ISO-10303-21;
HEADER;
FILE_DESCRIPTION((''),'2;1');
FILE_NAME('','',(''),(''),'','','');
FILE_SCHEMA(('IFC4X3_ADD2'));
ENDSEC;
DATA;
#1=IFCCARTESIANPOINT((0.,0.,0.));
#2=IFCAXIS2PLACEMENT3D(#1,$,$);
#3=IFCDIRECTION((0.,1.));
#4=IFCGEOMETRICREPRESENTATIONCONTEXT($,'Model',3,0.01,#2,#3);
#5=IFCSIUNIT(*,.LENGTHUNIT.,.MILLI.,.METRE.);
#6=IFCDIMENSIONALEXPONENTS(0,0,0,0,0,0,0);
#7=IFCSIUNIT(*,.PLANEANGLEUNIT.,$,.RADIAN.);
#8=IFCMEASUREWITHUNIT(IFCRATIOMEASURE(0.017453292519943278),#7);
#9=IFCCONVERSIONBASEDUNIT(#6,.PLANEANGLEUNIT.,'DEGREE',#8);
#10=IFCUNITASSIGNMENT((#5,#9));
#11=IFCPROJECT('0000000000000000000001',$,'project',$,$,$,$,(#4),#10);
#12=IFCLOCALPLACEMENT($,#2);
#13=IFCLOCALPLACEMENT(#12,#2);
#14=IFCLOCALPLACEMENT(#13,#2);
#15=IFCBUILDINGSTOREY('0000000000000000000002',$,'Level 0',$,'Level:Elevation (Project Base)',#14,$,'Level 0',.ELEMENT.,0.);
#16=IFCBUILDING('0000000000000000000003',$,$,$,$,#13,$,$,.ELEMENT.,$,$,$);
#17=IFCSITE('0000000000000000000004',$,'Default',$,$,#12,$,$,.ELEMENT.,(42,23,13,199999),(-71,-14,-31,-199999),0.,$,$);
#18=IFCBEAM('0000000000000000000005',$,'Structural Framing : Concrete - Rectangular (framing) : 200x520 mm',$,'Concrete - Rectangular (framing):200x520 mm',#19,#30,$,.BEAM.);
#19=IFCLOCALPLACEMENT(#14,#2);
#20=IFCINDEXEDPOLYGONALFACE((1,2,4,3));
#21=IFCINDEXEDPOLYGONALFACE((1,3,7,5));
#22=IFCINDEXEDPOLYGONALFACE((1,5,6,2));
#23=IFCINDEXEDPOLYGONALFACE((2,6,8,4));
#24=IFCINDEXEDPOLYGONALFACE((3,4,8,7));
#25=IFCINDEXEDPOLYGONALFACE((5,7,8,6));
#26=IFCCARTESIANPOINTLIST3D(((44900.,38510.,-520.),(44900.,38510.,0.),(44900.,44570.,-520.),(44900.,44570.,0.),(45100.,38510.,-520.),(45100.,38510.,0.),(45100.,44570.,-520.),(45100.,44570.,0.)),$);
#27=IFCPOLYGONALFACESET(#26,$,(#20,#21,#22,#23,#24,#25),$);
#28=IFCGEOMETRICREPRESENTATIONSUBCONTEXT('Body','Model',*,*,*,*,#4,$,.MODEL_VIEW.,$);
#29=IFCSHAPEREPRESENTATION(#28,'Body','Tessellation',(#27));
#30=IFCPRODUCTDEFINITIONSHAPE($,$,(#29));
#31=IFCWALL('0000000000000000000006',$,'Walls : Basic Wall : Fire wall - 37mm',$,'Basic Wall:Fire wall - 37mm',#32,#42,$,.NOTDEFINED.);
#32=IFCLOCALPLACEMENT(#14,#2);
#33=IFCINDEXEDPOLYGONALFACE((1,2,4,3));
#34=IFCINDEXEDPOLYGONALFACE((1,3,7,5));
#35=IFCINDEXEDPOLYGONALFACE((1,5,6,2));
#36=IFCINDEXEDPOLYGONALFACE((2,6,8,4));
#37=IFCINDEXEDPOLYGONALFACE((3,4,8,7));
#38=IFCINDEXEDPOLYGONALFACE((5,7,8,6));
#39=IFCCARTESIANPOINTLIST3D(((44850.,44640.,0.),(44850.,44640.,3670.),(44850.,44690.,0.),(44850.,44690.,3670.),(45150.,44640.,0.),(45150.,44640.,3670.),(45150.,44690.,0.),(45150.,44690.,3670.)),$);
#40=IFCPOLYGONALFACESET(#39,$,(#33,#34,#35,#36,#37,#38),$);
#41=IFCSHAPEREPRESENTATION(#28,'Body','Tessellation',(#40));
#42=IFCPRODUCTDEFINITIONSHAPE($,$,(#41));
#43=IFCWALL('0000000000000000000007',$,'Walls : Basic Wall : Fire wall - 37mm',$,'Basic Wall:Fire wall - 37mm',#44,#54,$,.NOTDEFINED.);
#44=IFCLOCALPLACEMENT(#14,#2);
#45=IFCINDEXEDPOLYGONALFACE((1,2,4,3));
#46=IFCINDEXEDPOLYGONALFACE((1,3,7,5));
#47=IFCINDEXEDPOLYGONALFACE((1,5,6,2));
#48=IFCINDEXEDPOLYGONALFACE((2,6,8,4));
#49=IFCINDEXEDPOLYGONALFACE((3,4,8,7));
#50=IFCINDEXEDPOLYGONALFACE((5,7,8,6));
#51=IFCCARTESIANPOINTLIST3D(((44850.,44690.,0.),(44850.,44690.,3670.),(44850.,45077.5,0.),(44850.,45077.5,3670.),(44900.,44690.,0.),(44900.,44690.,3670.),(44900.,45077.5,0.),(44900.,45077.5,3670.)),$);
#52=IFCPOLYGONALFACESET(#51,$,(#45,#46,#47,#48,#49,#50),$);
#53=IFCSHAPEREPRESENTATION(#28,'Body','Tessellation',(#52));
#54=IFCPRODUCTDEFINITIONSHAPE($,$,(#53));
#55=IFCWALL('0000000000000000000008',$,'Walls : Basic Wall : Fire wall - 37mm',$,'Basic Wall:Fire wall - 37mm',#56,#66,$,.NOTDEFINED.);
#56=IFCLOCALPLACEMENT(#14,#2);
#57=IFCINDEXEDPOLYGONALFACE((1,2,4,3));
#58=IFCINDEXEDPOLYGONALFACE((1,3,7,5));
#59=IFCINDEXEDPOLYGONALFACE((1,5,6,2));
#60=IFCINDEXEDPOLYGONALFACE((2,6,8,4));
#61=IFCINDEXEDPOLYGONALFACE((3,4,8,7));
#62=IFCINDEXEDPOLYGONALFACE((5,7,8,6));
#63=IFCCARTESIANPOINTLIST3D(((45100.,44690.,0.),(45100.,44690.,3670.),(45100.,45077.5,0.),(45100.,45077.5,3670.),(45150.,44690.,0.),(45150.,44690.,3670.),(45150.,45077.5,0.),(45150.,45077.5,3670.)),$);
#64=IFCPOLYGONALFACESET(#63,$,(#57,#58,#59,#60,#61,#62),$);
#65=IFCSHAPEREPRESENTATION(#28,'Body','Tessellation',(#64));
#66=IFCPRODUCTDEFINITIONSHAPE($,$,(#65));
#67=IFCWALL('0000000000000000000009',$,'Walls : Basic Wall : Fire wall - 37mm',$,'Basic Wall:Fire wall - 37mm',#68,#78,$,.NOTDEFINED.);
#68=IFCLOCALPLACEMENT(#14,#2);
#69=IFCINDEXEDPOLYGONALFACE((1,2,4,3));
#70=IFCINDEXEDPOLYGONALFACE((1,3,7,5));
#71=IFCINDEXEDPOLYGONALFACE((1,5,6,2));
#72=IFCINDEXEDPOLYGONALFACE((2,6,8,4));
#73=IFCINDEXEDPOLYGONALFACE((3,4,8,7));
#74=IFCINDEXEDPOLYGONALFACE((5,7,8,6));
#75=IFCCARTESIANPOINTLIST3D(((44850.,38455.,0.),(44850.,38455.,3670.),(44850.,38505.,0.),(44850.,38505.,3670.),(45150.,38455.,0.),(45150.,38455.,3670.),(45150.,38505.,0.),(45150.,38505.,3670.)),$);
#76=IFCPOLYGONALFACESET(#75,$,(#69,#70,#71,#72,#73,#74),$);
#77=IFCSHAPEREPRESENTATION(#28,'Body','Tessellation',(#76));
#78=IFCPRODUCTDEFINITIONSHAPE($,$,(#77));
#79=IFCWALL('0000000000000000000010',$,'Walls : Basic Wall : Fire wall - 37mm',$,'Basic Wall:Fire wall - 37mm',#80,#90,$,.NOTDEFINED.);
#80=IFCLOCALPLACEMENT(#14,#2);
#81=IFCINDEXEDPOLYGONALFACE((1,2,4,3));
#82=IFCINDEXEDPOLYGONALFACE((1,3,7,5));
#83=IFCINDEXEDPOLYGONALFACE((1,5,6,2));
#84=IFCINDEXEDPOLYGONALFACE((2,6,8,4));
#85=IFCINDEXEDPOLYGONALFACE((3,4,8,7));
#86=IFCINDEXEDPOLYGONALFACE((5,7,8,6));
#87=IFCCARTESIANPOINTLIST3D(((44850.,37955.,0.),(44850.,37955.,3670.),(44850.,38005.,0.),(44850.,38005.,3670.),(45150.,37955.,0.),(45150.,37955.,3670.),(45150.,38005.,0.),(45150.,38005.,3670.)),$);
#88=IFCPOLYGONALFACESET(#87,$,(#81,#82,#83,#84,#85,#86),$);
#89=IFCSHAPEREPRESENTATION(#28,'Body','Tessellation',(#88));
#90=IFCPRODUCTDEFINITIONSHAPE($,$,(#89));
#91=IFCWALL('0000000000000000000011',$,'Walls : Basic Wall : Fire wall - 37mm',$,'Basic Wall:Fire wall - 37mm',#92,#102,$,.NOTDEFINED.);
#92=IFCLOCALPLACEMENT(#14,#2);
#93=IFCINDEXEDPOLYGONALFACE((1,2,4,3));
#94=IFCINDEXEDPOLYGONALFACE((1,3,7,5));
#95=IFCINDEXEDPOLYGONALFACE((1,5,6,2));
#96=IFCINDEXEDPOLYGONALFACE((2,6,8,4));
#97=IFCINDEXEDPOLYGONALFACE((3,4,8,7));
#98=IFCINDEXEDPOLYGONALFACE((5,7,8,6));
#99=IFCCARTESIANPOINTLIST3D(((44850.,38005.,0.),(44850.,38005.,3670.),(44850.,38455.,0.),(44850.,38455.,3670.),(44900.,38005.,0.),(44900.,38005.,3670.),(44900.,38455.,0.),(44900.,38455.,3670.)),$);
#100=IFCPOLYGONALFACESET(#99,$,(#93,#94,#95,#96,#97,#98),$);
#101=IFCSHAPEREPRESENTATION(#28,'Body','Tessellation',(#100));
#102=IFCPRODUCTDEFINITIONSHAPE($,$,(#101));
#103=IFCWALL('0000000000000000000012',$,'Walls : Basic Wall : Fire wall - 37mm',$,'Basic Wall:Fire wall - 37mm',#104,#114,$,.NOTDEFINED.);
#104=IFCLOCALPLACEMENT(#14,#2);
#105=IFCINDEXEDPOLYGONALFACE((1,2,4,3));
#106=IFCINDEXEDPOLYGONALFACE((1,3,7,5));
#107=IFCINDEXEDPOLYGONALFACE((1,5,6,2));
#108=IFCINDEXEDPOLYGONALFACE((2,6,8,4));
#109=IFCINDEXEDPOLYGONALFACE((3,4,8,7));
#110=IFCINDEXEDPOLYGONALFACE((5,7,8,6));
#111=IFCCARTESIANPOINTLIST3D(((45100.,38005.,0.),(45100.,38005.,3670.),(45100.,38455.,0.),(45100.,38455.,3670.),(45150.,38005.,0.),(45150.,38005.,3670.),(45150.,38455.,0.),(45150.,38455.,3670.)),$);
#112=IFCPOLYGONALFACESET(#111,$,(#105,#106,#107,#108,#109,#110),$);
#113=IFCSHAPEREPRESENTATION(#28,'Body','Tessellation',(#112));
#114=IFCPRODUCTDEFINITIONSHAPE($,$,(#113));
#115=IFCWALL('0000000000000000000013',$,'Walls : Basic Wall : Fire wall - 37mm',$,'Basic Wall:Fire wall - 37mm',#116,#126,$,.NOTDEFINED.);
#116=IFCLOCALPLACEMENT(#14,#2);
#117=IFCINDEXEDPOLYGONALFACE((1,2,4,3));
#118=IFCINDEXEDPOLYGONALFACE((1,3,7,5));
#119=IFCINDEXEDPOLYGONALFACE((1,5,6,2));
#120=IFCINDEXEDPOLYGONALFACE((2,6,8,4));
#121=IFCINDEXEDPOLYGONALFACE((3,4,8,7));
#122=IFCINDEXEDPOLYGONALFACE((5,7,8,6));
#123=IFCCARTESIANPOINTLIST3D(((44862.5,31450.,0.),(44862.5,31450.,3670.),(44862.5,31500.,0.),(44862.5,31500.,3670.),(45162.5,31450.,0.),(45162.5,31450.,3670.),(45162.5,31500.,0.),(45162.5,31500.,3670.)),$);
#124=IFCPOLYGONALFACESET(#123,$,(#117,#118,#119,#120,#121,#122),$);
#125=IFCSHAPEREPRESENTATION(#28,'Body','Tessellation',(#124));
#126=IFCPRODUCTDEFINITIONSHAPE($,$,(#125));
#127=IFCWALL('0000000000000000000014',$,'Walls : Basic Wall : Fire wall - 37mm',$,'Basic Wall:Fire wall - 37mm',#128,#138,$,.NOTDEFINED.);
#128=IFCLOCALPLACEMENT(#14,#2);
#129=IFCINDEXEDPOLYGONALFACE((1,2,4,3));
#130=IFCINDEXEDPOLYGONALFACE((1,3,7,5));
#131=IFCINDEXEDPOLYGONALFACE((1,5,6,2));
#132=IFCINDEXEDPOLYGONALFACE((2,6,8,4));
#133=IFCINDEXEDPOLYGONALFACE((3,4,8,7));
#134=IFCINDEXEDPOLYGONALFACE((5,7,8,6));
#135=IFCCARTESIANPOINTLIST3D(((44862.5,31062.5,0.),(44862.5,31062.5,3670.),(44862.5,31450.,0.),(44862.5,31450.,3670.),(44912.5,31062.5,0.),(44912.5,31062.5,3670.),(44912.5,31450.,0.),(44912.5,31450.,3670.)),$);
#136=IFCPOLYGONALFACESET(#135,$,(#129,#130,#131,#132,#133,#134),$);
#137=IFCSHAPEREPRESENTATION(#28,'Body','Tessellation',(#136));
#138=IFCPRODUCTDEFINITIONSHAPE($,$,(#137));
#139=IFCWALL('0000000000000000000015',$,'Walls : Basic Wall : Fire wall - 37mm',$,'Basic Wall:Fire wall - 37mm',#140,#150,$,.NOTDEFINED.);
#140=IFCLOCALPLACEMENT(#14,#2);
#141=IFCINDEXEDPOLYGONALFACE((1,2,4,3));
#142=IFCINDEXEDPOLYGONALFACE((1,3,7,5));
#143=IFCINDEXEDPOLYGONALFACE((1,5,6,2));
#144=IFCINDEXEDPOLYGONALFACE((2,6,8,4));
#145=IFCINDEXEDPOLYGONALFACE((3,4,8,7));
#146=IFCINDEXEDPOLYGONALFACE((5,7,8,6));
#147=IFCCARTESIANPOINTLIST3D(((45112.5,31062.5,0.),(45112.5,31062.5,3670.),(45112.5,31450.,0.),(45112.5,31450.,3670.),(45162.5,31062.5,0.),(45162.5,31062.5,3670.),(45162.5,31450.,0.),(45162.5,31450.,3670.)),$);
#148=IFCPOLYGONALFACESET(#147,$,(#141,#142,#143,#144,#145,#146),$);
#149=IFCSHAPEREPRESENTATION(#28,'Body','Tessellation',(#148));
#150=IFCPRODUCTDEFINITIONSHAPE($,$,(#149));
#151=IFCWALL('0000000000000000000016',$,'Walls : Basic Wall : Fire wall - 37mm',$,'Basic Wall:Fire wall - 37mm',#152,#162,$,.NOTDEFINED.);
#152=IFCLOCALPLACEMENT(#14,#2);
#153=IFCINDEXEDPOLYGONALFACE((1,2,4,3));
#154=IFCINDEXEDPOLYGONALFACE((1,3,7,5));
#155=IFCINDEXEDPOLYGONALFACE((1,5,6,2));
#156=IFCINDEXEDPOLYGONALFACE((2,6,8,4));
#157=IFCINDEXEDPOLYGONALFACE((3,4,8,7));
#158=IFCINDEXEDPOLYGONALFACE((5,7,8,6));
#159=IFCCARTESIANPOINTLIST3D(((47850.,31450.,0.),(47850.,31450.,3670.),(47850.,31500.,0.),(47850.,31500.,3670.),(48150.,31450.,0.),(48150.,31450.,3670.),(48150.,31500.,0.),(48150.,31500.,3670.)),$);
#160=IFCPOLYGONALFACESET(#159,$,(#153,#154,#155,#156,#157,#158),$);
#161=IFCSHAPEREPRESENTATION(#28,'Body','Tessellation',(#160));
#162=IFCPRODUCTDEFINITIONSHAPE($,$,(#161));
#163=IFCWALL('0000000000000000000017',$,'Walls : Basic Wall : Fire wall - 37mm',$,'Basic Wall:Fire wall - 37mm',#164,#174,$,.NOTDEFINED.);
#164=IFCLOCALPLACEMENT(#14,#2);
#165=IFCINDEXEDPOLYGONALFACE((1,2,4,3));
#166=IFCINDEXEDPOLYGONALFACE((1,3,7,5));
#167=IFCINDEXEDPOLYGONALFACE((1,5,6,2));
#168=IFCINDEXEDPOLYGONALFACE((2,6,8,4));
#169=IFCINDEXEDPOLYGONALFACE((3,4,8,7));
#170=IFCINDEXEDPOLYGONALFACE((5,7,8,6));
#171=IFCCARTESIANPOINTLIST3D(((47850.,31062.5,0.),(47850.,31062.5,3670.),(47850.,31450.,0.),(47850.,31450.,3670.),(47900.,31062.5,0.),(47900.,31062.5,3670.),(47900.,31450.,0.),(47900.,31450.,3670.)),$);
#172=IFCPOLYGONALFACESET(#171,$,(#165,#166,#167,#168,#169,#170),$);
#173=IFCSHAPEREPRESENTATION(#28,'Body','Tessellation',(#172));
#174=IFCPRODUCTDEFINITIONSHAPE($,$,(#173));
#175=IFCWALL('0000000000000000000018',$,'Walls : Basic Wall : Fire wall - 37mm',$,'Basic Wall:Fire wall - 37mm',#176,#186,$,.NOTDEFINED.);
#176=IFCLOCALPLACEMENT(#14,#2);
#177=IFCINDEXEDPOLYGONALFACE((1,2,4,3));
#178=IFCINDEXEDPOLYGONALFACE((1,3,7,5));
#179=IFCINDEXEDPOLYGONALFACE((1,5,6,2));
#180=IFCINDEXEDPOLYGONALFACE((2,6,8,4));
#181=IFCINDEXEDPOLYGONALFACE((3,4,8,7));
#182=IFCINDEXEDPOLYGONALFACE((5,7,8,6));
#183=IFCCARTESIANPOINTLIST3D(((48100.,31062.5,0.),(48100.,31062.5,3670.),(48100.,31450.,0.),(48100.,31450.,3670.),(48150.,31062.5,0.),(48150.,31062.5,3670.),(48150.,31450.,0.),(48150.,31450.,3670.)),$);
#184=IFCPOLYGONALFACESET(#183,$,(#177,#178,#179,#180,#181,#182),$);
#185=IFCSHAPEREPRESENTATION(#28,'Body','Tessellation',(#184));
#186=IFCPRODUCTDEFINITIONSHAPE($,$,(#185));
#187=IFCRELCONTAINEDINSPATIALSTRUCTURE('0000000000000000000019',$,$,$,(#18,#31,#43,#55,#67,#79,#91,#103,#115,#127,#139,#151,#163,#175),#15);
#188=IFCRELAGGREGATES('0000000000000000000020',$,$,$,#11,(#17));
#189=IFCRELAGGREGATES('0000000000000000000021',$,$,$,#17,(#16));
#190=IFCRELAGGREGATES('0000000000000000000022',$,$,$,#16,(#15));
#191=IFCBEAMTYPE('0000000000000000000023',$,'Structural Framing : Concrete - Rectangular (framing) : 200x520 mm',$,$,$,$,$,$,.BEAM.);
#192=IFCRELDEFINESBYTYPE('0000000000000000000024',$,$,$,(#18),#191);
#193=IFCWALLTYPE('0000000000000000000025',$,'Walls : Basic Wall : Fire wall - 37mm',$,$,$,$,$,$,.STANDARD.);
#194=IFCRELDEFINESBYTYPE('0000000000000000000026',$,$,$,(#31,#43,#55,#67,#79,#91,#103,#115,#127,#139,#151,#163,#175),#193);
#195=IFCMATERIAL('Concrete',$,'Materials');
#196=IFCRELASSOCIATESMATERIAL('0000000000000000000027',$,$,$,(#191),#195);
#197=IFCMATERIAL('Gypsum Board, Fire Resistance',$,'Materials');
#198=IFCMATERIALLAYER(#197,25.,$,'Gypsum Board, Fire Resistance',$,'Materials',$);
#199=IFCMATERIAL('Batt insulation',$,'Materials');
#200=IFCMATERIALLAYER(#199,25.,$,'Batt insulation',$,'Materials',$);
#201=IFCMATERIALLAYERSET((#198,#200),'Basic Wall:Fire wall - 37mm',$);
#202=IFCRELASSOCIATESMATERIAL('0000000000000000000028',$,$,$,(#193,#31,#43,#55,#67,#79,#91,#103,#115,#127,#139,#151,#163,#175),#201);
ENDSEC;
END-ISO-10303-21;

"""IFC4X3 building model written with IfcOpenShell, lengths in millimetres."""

from ifc_helpers import new_model, entity, si_unit, converted_unit, direction, frame, frame_2d, origin, place, context, subcontext, project, spatial, rectangle, extrude, source, transform, mapped, material, layer, layer_set, material_profile, profile_set, type_object, type_shapes, element, save


model = new_model("IFC4X3")

# Units and contexts
model_context = context("Model", 3, precision=0.01, world=origin(), true_north=direction((0.0, 1.0)))
body_context = subcontext(model_context, "Body", "Model", "MODEL_VIEW")
ifc_project = project(units=[si_unit("LENGTHUNIT", "METRE", prefix="MILLI"), converted_unit("PLANEANGLEUNIT", "DEGREE", entity("IfcRatioMeasure", 0.017453292519943278), si_unit("PLANEANGLEUNIT", "RADIAN"), dimensions=[0, 0, 0, 0, 0, 0, 0])], contexts=[model_context])

# Site, building, storey
site_placement = place(None, origin())
site = spatial("IfcSite", under=ifc_project, at=site_placement, Name="Default", CompositionType="ELEMENT", RefLatitude=(42, 23, 13, 199999), RefLongitude=(-71, -14, -31, -199999), RefElevation=0.0)
building_placement = place(site_placement, origin())
building = spatial("IfcBuilding", under=site, at=building_placement, CompositionType="ELEMENT")
storey_placement = place(building_placement, origin())
storey = spatial("IfcBuildingStorey", under=building, at=storey_placement, Name="Level 0", ObjectType="Level:Elevation (Project Base)", LongName="Level 0", CompositionType="ELEMENT", Elevation=0.0)

# Beam
ifc_material_1 = material(Name="Concrete", Category="Materials")
ifc_material_profile = material_profile(ifc_material_1, rectangle(XDim=520.0, YDim=200.0, at=frame_2d((0.0, 0.0), x_axis=(1.0, 0.0))), Name="200x520 mm")
ifc_profile_set = profile_set([ifc_material_profile], Name="200x520 mm")
beam_type = type_object("IfcBeamType", Name="Structural Framing : Concrete - Rectangular (framing) : 200x520 mm", PredefinedType="BEAM", material=ifc_profile_set)
shared_shape = source(origin(), body_context, "Body", "SweptSolid", [
    extrude(rectangle(XDim=520.0, YDim=200.0, at=frame_2d((0.0, 0.0), x_axis=(1.0, 0.0))), frame((-1230.0, 0.0, 0.0), z_axis=(1.0, 0.0, 0.0), x_axis=(0.0, 0.0, -1.0)), (0.0, 0.0, 1.0), 6060.0),
])
type_shapes(beam_type, [shared_shape])
beam_placement = place(storey_placement, frame((45000.0, 43340.0, -260.0), z_axis=(0.0, 0.0, 1.0), x_axis=(0.0, -1.0, 0.0)))
element("IfcBeam", 1, at=beam_placement, inside=storey, type_object=beam_type, Name="Structural Framing : Concrete - Rectangular (framing) : 200x520 mm", ObjectType="Concrete - Rectangular (framing):200x520 mm", PredefinedType="BEAM", context=body_context, shape_type="MappedRepresentation", body=[
    mapped(shared_shape, transform((0.0, 0.0, 0.0), scale=1.0)),
])

# Walls
ifc_material_2 = material(Name="Gypsum Board, Fire Resistance", Category="Materials")
ifc_layer_1 = layer(ifc_material_2, 25.0, Name="Gypsum Board, Fire Resistance", Category="Materials")
ifc_material_3 = material(Name="Batt insulation", Category="Materials")
ifc_layer_2 = layer(ifc_material_3, 25.0, Name="Batt insulation", Category="Materials")
ifc_layer_set = layer_set([ifc_layer_1, ifc_layer_2], Name="Basic Wall:Fire wall - 37mm")
wall_type = type_object("IfcWallType", Name="Walls : Basic Wall : Fire wall - 37mm", PredefinedType="STANDARD", material=ifc_layer_set)
wall_1_placement = place(storey_placement, frame((44850.0, 44665.0, 0.0)))
element("IfcWall", 2, at=wall_1_placement, inside=storey, type_object=wall_type, material=ifc_layer_set, Name="Walls : Basic Wall : Fire wall - 37mm", ObjectType="Basic Wall:Fire wall - 37mm", PredefinedType="NOTDEFINED", context=body_context, shape_type="SweptSolid", body=[
    extrude(rectangle(XDim=300.0, YDim=50.0, at=frame_2d((150.0, 0.0), x_axis=(-1.0, 0.0))), origin(), (0.0, 0.0, 1.0), 3670.0),
])
for number, where, z_axis, x_axis, name in (
    (3, (44875.0, 45077.5, 0.0), (0.0, 0.0, 1.0), (0.0, -1.0, 0.0), "Walls : Basic Wall : Fire wall - 37mm"),
    (4, (45125.0, 45077.5, 0.0), (0.0, 0.0, 1.0), (0.0, -1.0, 0.0), "Walls : Basic Wall : Fire wall - 37mm"),
):
    element("IfcWall", number, at=place(storey_placement, frame(where, z_axis=z_axis, x_axis=x_axis)), inside=storey, type_object=wall_type, material=ifc_layer_set, Name=name, ObjectType="Basic Wall:Fire wall - 37mm", PredefinedType="NOTDEFINED", context=body_context, shape_type="SweptSolid", body=[
        extrude(rectangle(XDim=387.5, YDim=50.0, at=frame_2d((193.7, 0.0), x_axis=(-1.0, 0.0))), origin(), (0.0, 0.0, 1.0), 3670.0),
    ])
wall_2_placement = place(storey_placement, frame((44850.0, 38480.0, 0.0)))
element("IfcWall", 5, at=wall_2_placement, inside=storey, type_object=wall_type, material=ifc_layer_set, Name="Walls : Basic Wall : Fire wall - 37mm", ObjectType="Basic Wall:Fire wall - 37mm", PredefinedType="NOTDEFINED", context=body_context, shape_type="SweptSolid", body=[
    extrude(rectangle(XDim=300.0, YDim=50.0, at=frame_2d((150.0, 0.0), x_axis=(-1.0, 0.0))), origin(), (0.0, 0.0, 1.0), 3670.0),
])
wall_3_placement = place(storey_placement, frame((44850.0, 37980.0, 0.0)))
element("IfcWall", 6, at=wall_3_placement, inside=storey, type_object=wall_type, material=ifc_layer_set, Name="Walls : Basic Wall : Fire wall - 37mm", ObjectType="Basic Wall:Fire wall - 37mm", PredefinedType="NOTDEFINED", context=body_context, shape_type="SweptSolid", body=[
    extrude(rectangle(XDim=300.0, YDim=50.0, at=frame_2d((150.0, 0.0), x_axis=(-1.0, 0.0))), origin(), (0.0, 0.0, 1.0), 3670.0),
])
for number, where, z_axis, x_axis, name in (
    (7, (44875.0, 38455.0, 0.0), (0.0, 0.0, 1.0), (0.0, -1.0, 0.0), "Walls : Basic Wall : Fire wall - 37mm"),
    (8, (45125.0, 38455.0, 0.0), (0.0, 0.0, 1.0), (0.0, -1.0, 0.0), "Walls : Basic Wall : Fire wall - 37mm"),
):
    element("IfcWall", number, at=place(storey_placement, frame(where, z_axis=z_axis, x_axis=x_axis)), inside=storey, type_object=wall_type, material=ifc_layer_set, Name=name, ObjectType="Basic Wall:Fire wall - 37mm", PredefinedType="NOTDEFINED", context=body_context, shape_type="SweptSolid", body=[
        extrude(rectangle(XDim=450.0, YDim=50.0, at=frame_2d((225.0, 0.0), x_axis=(-1.0, 0.0))), origin(), (0.0, 0.0, 1.0), 3670.0),
    ])
wall_4_placement = place(storey_placement, frame((44862.5, 31475.0, 0.0)))
element("IfcWall", 9, at=wall_4_placement, inside=storey, type_object=wall_type, material=ifc_layer_set, Name="Walls : Basic Wall : Fire wall - 37mm", ObjectType="Basic Wall:Fire wall - 37mm", PredefinedType="NOTDEFINED", context=body_context, shape_type="SweptSolid", body=[
    extrude(rectangle(XDim=300.0, YDim=50.0, at=frame_2d((150.0, 0.0), x_axis=(-1.0, 0.0))), origin(), (0.0, 0.0, 1.0), 3670.0),
])
for number, where, z_axis, x_axis, name in (
    (10, (44887.5, 31450.0, 0.0), (0.0, 0.0, 1.0), (0.0, -1.0, 0.0), "Walls : Basic Wall : Fire wall - 37mm"),
    (11, (45137.5, 31450.0, 0.0), (0.0, 0.0, 1.0), (0.0, -1.0, 0.0), "Walls : Basic Wall : Fire wall - 37mm"),
):
    element("IfcWall", number, at=place(storey_placement, frame(where, z_axis=z_axis, x_axis=x_axis)), inside=storey, type_object=wall_type, material=ifc_layer_set, Name=name, ObjectType="Basic Wall:Fire wall - 37mm", PredefinedType="NOTDEFINED", context=body_context, shape_type="SweptSolid", body=[
        extrude(rectangle(XDim=387.5, YDim=50.0, at=frame_2d((193.8, 0.0), x_axis=(-1.0, 0.0))), origin(), (0.0, 0.0, 1.0), 3670.0),
    ])
wall_5_placement = place(storey_placement, frame((47850.0, 31475.0, 0.0)))
element("IfcWall", 12, at=wall_5_placement, inside=storey, type_object=wall_type, material=ifc_layer_set, Name="Walls : Basic Wall : Fire wall - 37mm", ObjectType="Basic Wall:Fire wall - 37mm", PredefinedType="NOTDEFINED", context=body_context, shape_type="SweptSolid", body=[
    extrude(rectangle(XDim=300.0, YDim=50.0, at=frame_2d((150.0, 0.0), x_axis=(-1.0, 0.0))), origin(), (0.0, 0.0, 1.0), 3670.0),
])
wall_6_placement = place(storey_placement, frame((47875.0, 31450.0, 0.0), z_axis=(0.0, 0.0, 1.0), x_axis=(0.0, -1.0, 0.0)))
element("IfcWall", 13, at=wall_6_placement, inside=storey, type_object=wall_type, material=ifc_layer_set, Name="Walls : Basic Wall : Fire wall - 37mm", ObjectType="Basic Wall:Fire wall - 37mm", PredefinedType="NOTDEFINED", context=body_context, shape_type="SweptSolid", body=[
    extrude(rectangle(XDim=387.5, YDim=50.0, at=frame_2d((193.8, 0.0), x_axis=(-1.0, 0.0))), origin(), (0.0, 0.0, 1.0), 3670.0),
])
wall_7_placement = place(storey_placement, frame((48125.0, 31450.0, 0.0), z_axis=(0.0, 0.0, 1.0), x_axis=(0.0, -1.0, 0.0)))
element("IfcWall", 14, at=wall_7_placement, inside=storey, type_object=wall_type, material=ifc_layer_set, Name="Walls : Basic Wall : Fire wall - 37mm", ObjectType="Basic Wall:Fire wall - 37mm", PredefinedType="NOTDEFINED", context=body_context, shape_type="SweptSolid", body=[
    extrude(rectangle(XDim=387.5, YDim=50.0, at=frame_2d((193.8, 0.0), x_axis=(-1.0, 0.0))), origin(), (0.0, 0.0, 1.0), 3670.0),
])

save(model, "model.ifc")
